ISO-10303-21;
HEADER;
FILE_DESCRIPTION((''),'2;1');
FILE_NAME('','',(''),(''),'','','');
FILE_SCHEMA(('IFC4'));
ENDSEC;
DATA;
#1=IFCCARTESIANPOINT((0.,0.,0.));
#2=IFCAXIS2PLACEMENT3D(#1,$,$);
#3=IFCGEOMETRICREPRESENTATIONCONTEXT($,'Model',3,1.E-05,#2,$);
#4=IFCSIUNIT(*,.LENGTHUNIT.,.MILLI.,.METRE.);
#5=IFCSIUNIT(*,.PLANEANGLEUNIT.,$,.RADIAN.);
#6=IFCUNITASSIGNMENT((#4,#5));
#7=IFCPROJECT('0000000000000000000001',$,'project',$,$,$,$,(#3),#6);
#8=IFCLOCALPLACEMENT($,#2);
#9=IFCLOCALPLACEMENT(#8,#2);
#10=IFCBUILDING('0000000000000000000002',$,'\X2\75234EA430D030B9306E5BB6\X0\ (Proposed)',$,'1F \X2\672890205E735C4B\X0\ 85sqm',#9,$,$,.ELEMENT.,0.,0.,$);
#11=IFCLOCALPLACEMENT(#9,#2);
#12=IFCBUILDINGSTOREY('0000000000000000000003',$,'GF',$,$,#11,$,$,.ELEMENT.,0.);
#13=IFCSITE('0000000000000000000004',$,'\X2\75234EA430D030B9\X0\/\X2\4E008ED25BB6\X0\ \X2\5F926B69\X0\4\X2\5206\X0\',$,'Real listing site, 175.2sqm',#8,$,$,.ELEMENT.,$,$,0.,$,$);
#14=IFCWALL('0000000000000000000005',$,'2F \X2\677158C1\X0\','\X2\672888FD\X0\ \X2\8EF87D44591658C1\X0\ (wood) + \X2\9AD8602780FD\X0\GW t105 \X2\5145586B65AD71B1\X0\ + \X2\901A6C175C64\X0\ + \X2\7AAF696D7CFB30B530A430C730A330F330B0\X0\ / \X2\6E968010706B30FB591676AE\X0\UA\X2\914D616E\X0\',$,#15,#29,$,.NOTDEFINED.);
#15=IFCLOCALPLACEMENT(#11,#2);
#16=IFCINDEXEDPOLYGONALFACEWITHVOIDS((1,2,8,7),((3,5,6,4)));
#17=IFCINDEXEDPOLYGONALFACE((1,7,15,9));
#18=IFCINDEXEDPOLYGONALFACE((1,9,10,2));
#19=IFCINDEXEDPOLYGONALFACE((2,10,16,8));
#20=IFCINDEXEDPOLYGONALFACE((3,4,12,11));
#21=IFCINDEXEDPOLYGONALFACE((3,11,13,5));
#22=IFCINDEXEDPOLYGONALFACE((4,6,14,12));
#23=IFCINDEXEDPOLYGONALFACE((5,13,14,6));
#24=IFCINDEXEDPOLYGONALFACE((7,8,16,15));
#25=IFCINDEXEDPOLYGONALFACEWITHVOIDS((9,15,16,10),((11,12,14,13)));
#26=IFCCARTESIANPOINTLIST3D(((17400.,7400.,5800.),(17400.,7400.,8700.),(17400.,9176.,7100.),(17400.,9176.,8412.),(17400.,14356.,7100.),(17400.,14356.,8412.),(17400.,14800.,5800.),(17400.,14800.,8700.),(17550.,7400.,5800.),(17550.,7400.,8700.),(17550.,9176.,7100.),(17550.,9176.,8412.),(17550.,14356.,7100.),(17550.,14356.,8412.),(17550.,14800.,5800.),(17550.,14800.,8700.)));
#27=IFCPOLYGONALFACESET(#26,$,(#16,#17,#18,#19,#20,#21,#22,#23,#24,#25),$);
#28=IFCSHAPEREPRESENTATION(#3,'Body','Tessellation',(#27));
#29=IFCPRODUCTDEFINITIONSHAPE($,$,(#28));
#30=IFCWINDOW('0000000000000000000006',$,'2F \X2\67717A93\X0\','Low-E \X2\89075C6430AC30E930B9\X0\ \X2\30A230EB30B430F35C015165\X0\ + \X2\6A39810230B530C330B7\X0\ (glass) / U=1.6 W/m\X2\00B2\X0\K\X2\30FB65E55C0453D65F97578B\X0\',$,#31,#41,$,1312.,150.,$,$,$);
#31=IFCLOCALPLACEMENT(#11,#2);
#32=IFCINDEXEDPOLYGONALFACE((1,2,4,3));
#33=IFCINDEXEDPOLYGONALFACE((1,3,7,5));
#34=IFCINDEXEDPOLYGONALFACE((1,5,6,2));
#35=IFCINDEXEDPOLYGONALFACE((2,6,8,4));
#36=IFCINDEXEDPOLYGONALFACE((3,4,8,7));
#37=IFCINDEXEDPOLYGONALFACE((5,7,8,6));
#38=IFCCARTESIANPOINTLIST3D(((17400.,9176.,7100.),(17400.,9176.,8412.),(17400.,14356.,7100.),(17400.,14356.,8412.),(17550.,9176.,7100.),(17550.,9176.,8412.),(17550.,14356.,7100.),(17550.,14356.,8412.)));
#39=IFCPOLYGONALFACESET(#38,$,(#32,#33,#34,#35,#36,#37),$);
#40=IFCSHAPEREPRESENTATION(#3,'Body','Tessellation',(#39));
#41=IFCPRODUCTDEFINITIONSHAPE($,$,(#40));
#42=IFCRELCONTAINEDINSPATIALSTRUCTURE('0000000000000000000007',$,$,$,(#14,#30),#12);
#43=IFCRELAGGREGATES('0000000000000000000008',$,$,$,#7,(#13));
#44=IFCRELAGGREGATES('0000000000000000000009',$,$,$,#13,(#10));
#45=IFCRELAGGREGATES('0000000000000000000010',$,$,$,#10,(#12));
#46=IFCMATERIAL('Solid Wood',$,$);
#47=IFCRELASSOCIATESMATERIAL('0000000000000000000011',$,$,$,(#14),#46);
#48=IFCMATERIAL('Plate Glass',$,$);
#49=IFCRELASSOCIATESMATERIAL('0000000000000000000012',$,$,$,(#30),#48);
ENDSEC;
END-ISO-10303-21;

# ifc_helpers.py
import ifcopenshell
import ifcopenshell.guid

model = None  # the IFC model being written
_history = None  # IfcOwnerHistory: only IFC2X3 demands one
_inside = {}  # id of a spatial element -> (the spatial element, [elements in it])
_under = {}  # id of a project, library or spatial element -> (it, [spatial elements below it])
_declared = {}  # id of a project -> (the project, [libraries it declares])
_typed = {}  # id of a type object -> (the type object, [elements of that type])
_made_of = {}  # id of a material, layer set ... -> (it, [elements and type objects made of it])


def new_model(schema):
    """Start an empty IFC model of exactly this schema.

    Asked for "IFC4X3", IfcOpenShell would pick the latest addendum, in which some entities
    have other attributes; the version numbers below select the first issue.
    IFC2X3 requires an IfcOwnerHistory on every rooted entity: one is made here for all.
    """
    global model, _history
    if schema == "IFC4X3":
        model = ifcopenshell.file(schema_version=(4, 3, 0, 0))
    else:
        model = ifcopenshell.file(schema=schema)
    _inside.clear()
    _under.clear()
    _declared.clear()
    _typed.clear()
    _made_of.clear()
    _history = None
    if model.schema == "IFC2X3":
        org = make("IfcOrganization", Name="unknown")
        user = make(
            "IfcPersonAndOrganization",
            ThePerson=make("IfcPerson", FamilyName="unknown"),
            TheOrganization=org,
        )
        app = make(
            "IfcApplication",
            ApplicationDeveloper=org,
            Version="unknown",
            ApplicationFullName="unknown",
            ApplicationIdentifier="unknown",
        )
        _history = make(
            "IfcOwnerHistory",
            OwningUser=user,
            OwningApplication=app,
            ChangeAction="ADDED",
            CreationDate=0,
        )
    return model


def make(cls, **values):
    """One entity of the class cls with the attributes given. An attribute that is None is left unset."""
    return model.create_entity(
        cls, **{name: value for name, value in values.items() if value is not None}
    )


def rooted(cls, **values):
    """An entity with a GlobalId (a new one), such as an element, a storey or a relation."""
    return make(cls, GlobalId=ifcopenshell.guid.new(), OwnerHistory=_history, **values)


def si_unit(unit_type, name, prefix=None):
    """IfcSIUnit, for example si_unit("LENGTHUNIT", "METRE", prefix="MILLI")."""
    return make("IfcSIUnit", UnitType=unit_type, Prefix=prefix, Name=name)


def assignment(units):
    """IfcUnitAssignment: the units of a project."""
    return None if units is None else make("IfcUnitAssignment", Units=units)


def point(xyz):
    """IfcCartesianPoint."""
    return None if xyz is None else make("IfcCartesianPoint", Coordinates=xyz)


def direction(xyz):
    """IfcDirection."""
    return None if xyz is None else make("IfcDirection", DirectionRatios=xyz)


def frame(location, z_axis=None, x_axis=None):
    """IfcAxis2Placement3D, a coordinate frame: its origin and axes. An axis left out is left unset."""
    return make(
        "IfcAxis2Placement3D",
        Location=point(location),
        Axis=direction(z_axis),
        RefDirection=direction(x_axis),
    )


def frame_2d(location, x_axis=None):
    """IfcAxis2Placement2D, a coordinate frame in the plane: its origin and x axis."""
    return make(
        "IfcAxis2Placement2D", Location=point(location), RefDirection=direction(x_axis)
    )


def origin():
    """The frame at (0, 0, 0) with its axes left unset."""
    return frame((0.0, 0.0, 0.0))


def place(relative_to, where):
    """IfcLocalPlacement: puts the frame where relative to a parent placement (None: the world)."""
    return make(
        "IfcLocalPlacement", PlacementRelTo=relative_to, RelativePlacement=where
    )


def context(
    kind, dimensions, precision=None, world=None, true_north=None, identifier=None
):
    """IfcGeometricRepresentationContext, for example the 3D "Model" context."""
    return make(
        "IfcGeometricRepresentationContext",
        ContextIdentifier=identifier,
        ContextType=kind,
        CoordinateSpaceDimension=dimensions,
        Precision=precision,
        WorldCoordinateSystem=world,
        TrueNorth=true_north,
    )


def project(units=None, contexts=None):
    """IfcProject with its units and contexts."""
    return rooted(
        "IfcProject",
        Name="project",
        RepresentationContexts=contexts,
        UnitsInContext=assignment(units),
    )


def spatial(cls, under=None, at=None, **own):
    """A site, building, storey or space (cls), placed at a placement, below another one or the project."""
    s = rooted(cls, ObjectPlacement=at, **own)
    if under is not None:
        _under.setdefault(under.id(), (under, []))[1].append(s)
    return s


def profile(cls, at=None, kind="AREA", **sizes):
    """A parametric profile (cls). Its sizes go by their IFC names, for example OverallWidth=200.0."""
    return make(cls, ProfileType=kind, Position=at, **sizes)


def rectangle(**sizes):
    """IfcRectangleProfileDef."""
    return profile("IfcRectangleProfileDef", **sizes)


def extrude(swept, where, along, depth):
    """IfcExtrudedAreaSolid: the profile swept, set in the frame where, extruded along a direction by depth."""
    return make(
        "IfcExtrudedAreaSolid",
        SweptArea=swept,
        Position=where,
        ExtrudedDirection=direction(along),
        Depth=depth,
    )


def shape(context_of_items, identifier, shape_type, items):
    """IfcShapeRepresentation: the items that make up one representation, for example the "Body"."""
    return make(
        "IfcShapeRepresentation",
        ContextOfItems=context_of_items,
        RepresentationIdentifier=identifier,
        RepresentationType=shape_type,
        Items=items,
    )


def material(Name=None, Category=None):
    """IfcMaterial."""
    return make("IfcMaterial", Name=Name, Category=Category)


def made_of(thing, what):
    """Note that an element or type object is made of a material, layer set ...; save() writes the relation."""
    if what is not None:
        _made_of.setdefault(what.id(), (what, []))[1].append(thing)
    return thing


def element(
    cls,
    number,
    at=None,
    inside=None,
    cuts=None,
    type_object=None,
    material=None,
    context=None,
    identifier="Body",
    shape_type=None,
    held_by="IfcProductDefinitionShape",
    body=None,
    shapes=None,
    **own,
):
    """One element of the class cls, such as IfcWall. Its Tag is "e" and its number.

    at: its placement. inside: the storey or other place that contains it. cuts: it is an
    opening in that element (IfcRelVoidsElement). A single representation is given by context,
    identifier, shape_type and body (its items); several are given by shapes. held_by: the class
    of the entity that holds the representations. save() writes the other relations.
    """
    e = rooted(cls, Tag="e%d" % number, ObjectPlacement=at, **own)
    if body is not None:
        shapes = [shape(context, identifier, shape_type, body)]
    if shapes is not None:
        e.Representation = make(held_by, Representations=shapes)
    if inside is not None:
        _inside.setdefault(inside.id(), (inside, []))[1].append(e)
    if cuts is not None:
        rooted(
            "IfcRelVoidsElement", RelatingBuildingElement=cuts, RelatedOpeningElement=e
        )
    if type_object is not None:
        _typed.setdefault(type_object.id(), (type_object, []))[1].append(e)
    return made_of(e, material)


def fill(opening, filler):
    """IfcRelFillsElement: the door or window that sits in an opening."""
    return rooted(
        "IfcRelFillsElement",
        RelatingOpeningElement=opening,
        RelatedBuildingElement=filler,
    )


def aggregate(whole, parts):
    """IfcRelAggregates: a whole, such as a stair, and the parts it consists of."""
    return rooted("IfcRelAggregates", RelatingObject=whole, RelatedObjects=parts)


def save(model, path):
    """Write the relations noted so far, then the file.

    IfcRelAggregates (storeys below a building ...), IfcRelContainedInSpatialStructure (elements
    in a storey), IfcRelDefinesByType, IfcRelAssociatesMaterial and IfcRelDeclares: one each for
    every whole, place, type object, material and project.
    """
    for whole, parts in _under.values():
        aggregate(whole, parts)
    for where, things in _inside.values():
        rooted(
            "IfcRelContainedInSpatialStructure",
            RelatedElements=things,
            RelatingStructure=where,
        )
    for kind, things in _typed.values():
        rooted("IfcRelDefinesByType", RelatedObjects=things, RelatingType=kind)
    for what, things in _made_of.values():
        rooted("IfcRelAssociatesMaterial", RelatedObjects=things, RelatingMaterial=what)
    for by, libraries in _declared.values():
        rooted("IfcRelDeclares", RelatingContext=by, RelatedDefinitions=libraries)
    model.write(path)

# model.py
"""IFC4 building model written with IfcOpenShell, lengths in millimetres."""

from ifc_helpers import new_model, si_unit, frame, frame_2d, origin, place, context, project, spatial, rectangle, extrude, material, element, fill, save


model = new_model("IFC4")

# Units and contexts
model_context = context("Model", 3, precision=1e-05, world=origin())
ifc_project = project(units=[si_unit("LENGTHUNIT", "METRE", prefix="MILLI"), si_unit("PLANEANGLEUNIT", "RADIAN")], contexts=[model_context])

# Site, building, storey
site_placement = place(None, origin())
site = spatial("IfcSite", under=ifc_project, at=site_placement, Name="産交バス/一軒家 徒歩4分", ObjectType="Real listing site, 175.2sqm", CompositionType="ELEMENT", RefElevation=0.0)
building_placement = place(site_placement, origin())
building = spatial("IfcBuilding", under=site, at=building_placement, Name="産交バスの家 (Proposed)", ObjectType="1F 木造平屋 85sqm", CompositionType="ELEMENT", ElevationOfRefHeight=0.0, ElevationOfTerrain=0.0)
storey_placement = place(building_placement, origin())
storey = spatial("IfcBuildingStorey", under=building, at=storey_placement, Name="GF", CompositionType="ELEMENT", Elevation=0.0)

# Shared definitions
ifc_material_1 = material(Name="Solid Wood")

# Shared definitions
ifc_material_2 = material(Name="Plate Glass")

# Wall, opening, window
wall_1_placement = place(storey_placement, frame((8700.0, 3700.0, 2900.0)))
wall_1 = element("IfcWall", 1, at=wall_1_placement, inside=storey, material=ifc_material_1, Name="2F 東壁", Description="木製 軸組外壁 (wood) + 高性能GW t105 充填断熱 + 通気層 + 窯業系サイディング / 準耐火・外皮UA配慮", PredefinedType="NOTDEFINED", context=model_context, shape_type="SweptSolid", body=[
    extrude(rectangle(XDim=150.0, YDim=7400.0, at=frame_2d((75.0, 3700.0))), frame((8700.0, 3700.0, 2900.0)), (0.0, 0.0, 1.0), 2900.0),
])
opening_1_placement = place(storey_placement, frame((8700.0, 4588.0, 3550.0)))
opening_1 = element("IfcOpeningElement", 2, at=opening_1_placement, cuts=wall_1, PredefinedType="NOTDEFINED", context=model_context, shape_type="SweptSolid", body=[
    extrude(rectangle(XDim=150.0, YDim=5180.0, at=frame_2d((75.0, 2590.0))), frame((8700.0, 4588.0, 3550.0)), (0.0, 0.0, 1.0), 1312.0),
])
window_1_placement = place(storey_placement, frame((8700.0, 4588.0, 3550.0)))
window_1 = element("IfcWindow", 3, at=window_1_placement, inside=storey, material=ifc_material_2, Name="2F 東窓", Description="Low-E 複層ガラス アルゴン封入 + 樹脂サッシ (glass) / U=1.6 W/m²K・日射取得型", OverallHeight=1312.0, OverallWidth=150.0, context=model_context, shape_type="SweptSolid", body=[
    extrude(rectangle(XDim=150.0, YDim=5180.0, at=frame_2d((75.0, 2590.0))), frame((8700.0, 4588.0, 3550.0)), (0.0, 0.0, 1.0), 1312.0),
])
fill(opening_1, window_1)

save(model, "model.ifc")
